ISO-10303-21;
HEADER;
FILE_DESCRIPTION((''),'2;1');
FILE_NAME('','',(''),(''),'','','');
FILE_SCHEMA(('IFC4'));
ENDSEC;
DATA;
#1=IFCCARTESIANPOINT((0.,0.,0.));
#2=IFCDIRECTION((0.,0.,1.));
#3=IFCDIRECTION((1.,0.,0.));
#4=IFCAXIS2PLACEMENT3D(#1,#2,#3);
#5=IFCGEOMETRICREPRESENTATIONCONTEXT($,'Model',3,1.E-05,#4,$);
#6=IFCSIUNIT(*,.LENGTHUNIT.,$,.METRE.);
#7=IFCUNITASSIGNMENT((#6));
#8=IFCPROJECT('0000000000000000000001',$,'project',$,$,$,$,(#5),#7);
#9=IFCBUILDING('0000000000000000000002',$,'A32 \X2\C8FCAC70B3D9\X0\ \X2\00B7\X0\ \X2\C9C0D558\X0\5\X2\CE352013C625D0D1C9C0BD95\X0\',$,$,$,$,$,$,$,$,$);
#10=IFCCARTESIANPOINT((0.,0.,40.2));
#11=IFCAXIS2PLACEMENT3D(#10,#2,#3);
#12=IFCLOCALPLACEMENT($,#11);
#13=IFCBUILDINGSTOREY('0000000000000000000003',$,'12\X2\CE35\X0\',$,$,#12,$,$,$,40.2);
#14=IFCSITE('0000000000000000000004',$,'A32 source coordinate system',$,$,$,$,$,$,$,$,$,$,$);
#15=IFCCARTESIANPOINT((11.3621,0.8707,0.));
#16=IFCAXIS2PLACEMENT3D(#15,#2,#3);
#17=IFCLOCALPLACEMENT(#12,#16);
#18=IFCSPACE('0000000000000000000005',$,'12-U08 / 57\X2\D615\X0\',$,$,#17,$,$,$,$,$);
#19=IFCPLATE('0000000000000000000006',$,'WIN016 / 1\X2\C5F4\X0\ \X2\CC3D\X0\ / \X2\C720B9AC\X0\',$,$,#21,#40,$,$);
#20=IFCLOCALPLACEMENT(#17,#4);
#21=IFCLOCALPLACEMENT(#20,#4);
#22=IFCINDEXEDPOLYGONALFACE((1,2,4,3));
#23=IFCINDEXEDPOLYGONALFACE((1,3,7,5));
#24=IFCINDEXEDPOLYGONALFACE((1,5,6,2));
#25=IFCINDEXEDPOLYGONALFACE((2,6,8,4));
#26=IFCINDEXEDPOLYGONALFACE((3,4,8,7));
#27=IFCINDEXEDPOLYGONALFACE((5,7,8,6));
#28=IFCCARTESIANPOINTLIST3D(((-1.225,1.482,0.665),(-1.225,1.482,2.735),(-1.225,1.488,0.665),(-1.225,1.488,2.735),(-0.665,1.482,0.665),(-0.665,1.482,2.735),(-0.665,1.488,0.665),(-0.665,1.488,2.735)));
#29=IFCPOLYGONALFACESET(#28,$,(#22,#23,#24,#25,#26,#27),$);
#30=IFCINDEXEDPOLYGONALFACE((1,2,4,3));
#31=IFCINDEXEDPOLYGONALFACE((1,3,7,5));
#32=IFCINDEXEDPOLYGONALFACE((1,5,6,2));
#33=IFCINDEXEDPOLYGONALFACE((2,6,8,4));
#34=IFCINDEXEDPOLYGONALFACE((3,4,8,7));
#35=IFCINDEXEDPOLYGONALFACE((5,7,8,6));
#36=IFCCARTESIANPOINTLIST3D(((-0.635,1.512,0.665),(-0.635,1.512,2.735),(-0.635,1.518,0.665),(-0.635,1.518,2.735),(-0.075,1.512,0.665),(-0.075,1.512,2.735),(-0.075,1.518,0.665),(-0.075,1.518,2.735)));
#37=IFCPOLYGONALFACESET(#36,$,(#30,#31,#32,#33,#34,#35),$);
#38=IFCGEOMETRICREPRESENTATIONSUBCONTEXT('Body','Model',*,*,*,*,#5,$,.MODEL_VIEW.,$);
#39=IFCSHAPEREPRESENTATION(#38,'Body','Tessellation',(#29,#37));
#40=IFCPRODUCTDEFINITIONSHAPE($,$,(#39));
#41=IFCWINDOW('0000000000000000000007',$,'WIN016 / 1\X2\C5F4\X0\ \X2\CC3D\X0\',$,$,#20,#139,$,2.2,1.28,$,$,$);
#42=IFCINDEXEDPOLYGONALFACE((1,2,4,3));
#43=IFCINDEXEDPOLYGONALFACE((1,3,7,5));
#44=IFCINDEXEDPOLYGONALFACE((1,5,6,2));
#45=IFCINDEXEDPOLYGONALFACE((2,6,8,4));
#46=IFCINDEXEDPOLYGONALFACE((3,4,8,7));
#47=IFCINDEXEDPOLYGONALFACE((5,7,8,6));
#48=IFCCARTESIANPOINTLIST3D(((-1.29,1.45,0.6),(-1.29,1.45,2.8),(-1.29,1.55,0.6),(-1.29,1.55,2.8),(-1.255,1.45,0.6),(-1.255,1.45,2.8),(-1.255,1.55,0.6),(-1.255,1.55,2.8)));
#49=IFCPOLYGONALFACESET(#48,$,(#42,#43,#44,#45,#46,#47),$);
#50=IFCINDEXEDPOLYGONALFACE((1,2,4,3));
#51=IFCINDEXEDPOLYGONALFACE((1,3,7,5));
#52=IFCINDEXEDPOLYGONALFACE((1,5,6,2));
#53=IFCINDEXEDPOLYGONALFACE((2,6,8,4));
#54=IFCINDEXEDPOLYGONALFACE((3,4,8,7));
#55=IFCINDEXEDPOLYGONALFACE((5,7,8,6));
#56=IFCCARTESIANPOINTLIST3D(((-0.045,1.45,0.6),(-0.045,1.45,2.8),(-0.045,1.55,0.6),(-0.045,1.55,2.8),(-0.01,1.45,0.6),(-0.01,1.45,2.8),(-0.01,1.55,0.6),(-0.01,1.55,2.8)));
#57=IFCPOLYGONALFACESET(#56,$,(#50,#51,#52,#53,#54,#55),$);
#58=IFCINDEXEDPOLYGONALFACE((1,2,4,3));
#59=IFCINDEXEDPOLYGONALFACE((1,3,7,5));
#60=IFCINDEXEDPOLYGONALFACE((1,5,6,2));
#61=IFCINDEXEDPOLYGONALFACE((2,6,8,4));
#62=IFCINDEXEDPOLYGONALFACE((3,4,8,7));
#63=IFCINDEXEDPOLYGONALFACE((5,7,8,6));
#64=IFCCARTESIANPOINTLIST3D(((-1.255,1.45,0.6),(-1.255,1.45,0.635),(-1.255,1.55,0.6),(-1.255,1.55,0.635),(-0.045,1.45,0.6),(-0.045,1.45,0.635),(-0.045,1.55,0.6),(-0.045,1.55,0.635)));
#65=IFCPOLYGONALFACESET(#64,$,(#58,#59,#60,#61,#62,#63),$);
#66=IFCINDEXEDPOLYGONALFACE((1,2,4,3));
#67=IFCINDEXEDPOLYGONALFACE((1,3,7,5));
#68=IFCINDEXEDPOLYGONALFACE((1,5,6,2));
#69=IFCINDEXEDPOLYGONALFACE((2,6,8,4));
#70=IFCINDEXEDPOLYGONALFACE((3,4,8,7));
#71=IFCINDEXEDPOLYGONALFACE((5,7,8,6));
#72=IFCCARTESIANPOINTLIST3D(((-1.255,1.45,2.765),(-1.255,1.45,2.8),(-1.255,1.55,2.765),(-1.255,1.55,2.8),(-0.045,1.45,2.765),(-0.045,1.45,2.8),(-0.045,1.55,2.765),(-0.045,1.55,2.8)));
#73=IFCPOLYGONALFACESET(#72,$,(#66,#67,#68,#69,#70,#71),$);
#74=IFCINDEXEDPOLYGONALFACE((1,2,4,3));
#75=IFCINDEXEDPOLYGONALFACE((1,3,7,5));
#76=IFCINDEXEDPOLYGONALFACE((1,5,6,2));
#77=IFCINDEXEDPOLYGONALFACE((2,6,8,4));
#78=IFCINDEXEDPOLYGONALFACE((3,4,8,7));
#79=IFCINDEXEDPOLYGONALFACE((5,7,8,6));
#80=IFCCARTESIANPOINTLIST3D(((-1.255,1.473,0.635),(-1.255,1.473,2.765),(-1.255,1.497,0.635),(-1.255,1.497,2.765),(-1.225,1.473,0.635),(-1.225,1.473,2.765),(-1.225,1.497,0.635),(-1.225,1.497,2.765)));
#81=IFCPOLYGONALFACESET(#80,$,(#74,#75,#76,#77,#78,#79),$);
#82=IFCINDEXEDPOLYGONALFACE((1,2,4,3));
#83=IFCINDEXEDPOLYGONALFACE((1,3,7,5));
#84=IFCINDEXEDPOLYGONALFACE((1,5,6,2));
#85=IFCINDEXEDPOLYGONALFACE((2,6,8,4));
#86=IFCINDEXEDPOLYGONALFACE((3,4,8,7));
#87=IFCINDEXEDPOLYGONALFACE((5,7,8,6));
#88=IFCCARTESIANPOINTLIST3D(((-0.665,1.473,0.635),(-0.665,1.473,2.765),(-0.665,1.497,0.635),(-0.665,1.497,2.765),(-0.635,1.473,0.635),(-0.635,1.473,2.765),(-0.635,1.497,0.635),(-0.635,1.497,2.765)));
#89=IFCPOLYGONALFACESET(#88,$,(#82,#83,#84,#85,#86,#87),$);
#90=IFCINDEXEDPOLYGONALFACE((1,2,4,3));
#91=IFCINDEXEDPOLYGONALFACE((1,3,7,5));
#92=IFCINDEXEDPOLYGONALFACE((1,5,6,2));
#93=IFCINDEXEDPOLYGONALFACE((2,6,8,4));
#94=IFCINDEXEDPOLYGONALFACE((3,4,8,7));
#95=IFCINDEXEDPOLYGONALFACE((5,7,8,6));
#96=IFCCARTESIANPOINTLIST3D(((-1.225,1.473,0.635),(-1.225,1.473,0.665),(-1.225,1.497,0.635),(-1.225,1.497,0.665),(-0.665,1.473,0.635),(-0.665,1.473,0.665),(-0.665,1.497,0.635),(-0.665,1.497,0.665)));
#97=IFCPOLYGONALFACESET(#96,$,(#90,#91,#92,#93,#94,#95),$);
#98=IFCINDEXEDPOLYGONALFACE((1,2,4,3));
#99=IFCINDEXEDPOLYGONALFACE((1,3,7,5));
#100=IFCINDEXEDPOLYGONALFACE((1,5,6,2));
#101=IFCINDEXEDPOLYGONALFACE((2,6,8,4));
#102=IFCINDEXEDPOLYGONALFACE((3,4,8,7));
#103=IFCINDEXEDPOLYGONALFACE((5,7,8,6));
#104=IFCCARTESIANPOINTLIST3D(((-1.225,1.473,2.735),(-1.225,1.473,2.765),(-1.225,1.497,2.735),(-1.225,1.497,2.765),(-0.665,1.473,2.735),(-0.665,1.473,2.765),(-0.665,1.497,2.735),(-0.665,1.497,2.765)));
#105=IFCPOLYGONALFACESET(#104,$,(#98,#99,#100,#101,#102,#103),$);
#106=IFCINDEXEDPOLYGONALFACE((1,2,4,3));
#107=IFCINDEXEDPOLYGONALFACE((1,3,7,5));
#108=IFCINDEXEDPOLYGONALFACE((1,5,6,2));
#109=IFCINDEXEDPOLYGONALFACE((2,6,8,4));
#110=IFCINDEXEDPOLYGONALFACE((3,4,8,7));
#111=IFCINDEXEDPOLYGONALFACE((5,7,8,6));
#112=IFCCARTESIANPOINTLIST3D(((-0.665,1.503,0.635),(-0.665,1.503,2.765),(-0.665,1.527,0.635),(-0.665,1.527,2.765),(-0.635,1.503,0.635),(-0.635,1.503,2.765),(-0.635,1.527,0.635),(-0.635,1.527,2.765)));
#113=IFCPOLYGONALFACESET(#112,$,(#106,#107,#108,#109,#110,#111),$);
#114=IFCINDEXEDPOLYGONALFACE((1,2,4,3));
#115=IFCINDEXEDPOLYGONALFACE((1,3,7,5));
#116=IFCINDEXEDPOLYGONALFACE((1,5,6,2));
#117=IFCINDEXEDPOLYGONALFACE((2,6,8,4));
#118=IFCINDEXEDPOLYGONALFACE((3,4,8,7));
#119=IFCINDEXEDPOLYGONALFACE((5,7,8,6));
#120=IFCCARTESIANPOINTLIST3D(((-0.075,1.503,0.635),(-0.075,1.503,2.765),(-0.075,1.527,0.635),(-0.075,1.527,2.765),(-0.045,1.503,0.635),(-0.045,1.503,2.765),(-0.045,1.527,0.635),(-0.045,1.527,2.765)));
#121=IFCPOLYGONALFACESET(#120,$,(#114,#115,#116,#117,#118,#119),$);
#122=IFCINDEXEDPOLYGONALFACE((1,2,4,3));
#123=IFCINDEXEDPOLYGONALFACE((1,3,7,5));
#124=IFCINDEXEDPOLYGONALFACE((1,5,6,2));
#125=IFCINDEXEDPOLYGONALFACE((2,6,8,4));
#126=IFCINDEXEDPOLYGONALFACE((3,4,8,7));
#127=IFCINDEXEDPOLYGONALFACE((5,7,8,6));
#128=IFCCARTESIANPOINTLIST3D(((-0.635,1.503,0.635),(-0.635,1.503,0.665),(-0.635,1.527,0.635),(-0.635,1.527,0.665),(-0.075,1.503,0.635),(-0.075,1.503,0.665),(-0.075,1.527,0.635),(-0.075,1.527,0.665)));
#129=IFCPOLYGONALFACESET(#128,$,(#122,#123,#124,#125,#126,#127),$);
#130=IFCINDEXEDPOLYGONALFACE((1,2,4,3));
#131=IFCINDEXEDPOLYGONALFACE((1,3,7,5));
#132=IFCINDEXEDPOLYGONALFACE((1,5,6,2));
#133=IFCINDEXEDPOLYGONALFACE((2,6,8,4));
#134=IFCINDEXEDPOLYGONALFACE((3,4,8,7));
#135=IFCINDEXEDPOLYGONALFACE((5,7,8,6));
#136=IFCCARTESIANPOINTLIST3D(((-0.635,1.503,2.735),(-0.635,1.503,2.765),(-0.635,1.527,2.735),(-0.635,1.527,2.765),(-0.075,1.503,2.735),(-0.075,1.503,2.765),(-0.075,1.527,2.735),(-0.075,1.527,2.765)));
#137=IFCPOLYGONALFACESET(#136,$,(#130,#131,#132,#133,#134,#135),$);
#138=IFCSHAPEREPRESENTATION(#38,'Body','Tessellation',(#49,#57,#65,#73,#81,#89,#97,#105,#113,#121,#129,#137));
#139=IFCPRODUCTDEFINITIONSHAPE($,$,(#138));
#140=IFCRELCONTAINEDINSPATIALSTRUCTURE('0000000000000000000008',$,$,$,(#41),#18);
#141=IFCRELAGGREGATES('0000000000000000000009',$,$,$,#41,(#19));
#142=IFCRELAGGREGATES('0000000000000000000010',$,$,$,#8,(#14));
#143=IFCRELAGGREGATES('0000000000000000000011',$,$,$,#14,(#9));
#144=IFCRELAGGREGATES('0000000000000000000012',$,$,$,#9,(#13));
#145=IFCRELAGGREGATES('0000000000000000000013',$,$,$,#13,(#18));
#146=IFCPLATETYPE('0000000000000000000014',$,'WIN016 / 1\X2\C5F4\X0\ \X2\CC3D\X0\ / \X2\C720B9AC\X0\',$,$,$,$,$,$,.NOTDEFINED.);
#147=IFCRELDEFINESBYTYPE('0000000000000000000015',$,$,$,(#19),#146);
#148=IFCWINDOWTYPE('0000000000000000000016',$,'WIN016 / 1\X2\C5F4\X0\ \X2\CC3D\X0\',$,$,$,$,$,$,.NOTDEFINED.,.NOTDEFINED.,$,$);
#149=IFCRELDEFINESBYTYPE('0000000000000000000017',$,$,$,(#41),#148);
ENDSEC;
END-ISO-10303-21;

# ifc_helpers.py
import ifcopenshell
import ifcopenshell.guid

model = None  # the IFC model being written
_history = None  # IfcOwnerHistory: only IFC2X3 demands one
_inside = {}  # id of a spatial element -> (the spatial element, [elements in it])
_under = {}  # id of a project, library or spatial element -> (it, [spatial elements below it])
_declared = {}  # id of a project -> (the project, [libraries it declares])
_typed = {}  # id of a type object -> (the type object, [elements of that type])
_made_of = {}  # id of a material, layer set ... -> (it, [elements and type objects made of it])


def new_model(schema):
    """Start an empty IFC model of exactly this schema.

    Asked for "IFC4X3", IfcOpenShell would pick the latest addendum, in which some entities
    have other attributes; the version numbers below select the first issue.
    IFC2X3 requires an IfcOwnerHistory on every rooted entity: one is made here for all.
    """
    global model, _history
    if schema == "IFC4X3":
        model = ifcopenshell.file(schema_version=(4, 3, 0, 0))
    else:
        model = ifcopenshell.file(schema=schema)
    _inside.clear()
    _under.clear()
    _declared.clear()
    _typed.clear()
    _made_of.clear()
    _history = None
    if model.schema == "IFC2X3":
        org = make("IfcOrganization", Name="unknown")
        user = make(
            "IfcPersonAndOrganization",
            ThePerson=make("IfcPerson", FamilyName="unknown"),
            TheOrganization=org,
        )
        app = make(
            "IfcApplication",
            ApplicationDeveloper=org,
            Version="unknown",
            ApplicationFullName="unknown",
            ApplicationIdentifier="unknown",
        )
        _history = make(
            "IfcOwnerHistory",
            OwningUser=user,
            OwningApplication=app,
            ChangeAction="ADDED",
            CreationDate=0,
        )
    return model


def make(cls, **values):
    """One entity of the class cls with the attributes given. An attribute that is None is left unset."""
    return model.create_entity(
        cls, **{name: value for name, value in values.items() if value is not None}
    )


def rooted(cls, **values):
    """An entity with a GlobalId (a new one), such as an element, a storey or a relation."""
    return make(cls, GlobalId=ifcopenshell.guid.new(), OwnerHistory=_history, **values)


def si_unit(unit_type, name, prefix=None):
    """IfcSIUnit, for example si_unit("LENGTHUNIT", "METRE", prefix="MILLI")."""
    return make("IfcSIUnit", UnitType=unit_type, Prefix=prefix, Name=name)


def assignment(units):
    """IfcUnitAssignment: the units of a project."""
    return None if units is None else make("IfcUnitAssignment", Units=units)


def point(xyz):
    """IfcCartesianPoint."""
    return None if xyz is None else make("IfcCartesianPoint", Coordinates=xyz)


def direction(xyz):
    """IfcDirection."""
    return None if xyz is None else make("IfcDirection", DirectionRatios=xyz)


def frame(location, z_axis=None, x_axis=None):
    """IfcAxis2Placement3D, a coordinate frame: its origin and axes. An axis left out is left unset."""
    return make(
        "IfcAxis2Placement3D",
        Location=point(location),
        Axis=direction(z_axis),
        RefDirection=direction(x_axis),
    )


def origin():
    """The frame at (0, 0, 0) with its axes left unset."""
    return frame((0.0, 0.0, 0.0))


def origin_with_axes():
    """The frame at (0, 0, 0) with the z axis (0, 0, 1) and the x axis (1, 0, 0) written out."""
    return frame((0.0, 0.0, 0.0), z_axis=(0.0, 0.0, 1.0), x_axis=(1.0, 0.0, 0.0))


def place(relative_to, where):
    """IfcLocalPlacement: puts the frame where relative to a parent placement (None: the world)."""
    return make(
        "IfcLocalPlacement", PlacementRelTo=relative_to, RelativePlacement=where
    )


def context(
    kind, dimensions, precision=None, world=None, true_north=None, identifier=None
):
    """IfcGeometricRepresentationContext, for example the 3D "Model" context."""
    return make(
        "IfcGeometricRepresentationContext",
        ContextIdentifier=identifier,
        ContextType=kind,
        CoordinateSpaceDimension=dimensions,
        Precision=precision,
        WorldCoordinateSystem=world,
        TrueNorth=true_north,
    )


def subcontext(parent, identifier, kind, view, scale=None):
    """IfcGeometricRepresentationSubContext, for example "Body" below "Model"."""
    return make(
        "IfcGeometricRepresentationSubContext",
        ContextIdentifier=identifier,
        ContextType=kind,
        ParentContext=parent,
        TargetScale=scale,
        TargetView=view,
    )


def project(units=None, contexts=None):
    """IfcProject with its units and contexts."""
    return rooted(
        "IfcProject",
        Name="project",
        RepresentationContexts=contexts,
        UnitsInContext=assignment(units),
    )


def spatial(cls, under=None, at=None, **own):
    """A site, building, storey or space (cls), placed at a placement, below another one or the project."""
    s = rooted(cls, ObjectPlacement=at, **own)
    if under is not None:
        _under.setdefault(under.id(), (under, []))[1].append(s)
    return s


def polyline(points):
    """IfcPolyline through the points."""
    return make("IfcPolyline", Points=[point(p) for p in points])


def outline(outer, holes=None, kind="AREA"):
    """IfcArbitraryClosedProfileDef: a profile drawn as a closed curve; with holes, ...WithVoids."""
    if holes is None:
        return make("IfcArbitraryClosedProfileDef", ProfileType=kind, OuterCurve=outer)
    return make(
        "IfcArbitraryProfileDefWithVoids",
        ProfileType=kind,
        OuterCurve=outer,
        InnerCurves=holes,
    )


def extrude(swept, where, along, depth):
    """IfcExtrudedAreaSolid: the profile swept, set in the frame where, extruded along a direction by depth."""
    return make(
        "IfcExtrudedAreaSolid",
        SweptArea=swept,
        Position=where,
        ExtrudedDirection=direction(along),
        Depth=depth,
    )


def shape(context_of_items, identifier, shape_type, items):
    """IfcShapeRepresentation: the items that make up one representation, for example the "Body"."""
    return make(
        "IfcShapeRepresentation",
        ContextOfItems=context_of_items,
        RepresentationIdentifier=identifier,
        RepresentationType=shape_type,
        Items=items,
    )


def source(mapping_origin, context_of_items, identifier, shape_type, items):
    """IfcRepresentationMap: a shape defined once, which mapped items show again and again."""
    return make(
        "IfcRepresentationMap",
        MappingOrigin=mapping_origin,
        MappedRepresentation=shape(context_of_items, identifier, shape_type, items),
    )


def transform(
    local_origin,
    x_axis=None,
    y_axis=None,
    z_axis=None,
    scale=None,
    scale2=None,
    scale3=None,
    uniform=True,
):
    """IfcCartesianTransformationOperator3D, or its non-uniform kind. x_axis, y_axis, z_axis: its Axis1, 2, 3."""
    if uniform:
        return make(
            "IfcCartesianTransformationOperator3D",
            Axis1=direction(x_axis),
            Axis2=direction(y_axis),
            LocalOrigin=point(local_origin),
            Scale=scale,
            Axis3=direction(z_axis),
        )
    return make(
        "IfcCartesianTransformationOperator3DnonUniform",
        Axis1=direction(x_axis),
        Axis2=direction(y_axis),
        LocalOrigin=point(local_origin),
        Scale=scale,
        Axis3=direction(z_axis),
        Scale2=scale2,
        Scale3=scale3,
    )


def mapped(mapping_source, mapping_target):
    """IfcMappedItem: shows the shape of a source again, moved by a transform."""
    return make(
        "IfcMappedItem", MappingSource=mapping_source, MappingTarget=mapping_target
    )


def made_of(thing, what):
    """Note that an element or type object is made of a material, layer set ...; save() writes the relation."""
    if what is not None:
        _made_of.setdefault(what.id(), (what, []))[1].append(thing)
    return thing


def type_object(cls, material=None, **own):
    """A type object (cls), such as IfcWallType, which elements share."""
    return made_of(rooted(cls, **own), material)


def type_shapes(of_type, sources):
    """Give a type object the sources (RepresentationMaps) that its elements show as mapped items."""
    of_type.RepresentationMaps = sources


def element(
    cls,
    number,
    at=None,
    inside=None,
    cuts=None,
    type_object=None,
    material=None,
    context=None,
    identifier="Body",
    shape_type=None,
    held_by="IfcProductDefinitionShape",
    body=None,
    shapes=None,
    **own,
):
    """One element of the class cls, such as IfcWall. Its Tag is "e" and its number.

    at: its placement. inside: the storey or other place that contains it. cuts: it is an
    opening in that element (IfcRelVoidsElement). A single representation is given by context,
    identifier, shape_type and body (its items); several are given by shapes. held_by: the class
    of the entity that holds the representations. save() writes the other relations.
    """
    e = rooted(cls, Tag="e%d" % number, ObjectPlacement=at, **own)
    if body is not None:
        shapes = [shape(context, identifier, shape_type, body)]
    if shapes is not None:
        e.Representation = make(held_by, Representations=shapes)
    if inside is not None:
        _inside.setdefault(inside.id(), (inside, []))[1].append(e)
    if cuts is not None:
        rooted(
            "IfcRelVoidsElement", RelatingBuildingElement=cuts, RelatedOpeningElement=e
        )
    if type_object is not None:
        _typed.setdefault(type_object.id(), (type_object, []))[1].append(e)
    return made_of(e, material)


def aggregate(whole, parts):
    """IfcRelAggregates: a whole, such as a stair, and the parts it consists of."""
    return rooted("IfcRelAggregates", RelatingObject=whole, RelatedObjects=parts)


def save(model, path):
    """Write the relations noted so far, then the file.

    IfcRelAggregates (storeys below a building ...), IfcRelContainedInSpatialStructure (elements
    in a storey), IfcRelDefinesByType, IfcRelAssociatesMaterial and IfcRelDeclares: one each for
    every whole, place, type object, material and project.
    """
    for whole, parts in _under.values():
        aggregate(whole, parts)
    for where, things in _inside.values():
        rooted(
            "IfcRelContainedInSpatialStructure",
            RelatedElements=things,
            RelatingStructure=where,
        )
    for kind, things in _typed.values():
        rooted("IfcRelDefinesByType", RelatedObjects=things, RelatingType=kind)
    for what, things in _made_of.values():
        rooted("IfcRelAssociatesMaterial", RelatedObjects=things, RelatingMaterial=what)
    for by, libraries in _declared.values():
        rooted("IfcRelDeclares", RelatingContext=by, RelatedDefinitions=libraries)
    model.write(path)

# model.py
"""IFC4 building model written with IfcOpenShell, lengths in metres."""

from ifc_helpers import new_model, si_unit, frame, origin, origin_with_axes, place, context, subcontext, project, spatial, polyline, outline, extrude, source, transform, mapped, type_object, type_shapes, element, aggregate, save


model = new_model("IFC4")

# Units and contexts
model_context = context("Model", 3, precision=1e-05, world=origin_with_axes())
body_context = subcontext(model_context, "Body", "Model", "MODEL_VIEW")
ifc_project = project(units=[si_unit("LENGTHUNIT", "METRE")], contexts=[model_context])

# Plate
storey_placement = place(None, frame((0.0, 0.0, 40.2), z_axis=(0.0, 0.0, 1.0), x_axis=(1.0, 0.0, 0.0)))
space_placement = place(storey_placement, frame((11.3621, 0.8707, 0.0), z_axis=(0.0, 0.0, 1.0), x_axis=(1.0, 0.0, 0.0)))
plate_type_1 = type_object("IfcPlateType", Name="WIN016 / 1열 창 / 유리", PredefinedType="NOTDEFINED")
shared_shape_1 = source(origin(), body_context, "Body", "SweptSolid", [
    extrude(outline(polyline([(-1.225, 1.482), (-1.225, 1.488), (-0.665, 1.488), (-0.665, 1.482), (-1.225, 1.482)])), frame((0.0, 0.0, 0.665)), (0.0, 0.0, 1.0), 2.07),
    extrude(outline(polyline([(-0.635, 1.512), (-0.635, 1.518), (-0.075, 1.518), (-0.075, 1.512), (-0.635, 1.512)])), frame((0.0, 0.0, 0.665)), (0.0, 0.0, 1.0), 2.07),
])
type_shapes(plate_type_1, [shared_shape_1])
window_1_placement = place(space_placement, origin_with_axes())
plate_1_placement = place(window_1_placement, origin_with_axes())
plate_1 = element("IfcPlate", 1, at=plate_1_placement, type_object=plate_type_1, Name="WIN016 / 1열 창 / 유리", context=body_context, shape_type="MappedRepresentation", body=[
    mapped(shared_shape_1, transform((0.0, 0.0, 0.0), scale=1.0)),
])

# Site, building, storey, space
site = spatial("IfcSite", under=ifc_project, Name="A32 source coordinate system")
building = spatial("IfcBuilding", under=site, Name="A32 주거동 · 지하5층–옥탑지붕")
storey = spatial("IfcBuildingStorey", under=building, at=storey_placement, Name="12층", Elevation=40.2)
space = spatial("IfcSpace", under=storey, at=space_placement, Name="12-U08 / 57형")

# Window
window_type_1 = type_object("IfcWindowType", Name="WIN016 / 1열 창", PartitioningType="NOTDEFINED", PredefinedType="NOTDEFINED")
shared_shape_2 = source(origin(), body_context, "Body", "SweptSolid", [
    extrude(outline(polyline([(-1.29, 1.45), (-1.29, 1.55), (-1.255, 1.55), (-1.255, 1.45), (-1.29, 1.45)])), frame((0.0, 0.0, 0.6)), (0.0, 0.0, 1.0), 2.2),
    extrude(outline(polyline([(-0.045, 1.45), (-0.045, 1.55), (-0.01, 1.55), (-0.01, 1.45), (-0.045, 1.45)])), frame((0.0, 0.0, 0.6)), (0.0, 0.0, 1.0), 2.2),
    extrude(outline(polyline([(-1.255, 1.45), (-1.255, 1.55), (-0.045, 1.55), (-0.045, 1.45), (-1.255, 1.45)])), frame((0.0, 0.0, 0.6)), (0.0, 0.0, 1.0), 0.035),
    extrude(outline(polyline([(-1.255, 1.45), (-1.255, 1.55), (-0.045, 1.55), (-0.045, 1.45), (-1.255, 1.45)])), frame((0.0, 0.0, 2.765)), (0.0, 0.0, 1.0), 0.035),
    extrude(outline(polyline([(-1.255, 1.473), (-1.255, 1.497), (-1.225, 1.497), (-1.225, 1.473), (-1.255, 1.473)])), frame((0.0, 0.0, 0.635)), (0.0, 0.0, 1.0), 2.13),
    extrude(outline(polyline([(-0.665, 1.473), (-0.665, 1.497), (-0.635, 1.497), (-0.635, 1.473), (-0.665, 1.473)])), frame((0.0, 0.0, 0.635)), (0.0, 0.0, 1.0), 2.13),
    extrude(outline(polyline([(-1.225, 1.473), (-1.225, 1.497), (-0.665, 1.497), (-0.665, 1.473), (-1.225, 1.473)])), frame((0.0, 0.0, 0.635)), (0.0, 0.0, 1.0), 0.03),
    extrude(outline(polyline([(-1.225, 1.473), (-1.225, 1.497), (-0.665, 1.497), (-0.665, 1.473), (-1.225, 1.473)])), frame((0.0, 0.0, 2.735)), (0.0, 0.0, 1.0), 0.03),
    extrude(outline(polyline([(-0.665, 1.503), (-0.665, 1.527), (-0.635, 1.527), (-0.635, 1.503), (-0.665, 1.503)])), frame((0.0, 0.0, 0.635)), (0.0, 0.0, 1.0), 2.13),
    extrude(outline(polyline([(-0.075, 1.503), (-0.075, 1.527), (-0.045, 1.527), (-0.045, 1.503), (-0.075, 1.503)])), frame((0.0, 0.0, 0.635)), (0.0, 0.0, 1.0), 2.13),
    extrude(outline(polyline([(-0.635, 1.503), (-0.635, 1.527), (-0.075, 1.527), (-0.075, 1.503), (-0.635, 1.503)])), frame((0.0, 0.0, 0.635)), (0.0, 0.0, 1.0), 0.03),
    extrude(outline(polyline([(-0.635, 1.503), (-0.635, 1.527), (-0.075, 1.527), (-0.075, 1.503), (-0.635, 1.503)])), frame((0.0, 0.0, 2.735)), (0.0, 0.0, 1.0), 0.03),
])
type_shapes(window_type_1, [shared_shape_2])
window_1 = element("IfcWindow", 2, at=window_1_placement, inside=space, type_object=window_type_1, Name="WIN016 / 1열 창", OverallHeight=2.2, OverallWidth=1.28, context=body_context, shape_type="MappedRepresentation", body=[
    mapped(shared_shape_2, transform((0.0, 0.0, 0.0), scale=1.0)),
])
aggregate(window_1, [plate_1])

save(model, "model.ifc")
